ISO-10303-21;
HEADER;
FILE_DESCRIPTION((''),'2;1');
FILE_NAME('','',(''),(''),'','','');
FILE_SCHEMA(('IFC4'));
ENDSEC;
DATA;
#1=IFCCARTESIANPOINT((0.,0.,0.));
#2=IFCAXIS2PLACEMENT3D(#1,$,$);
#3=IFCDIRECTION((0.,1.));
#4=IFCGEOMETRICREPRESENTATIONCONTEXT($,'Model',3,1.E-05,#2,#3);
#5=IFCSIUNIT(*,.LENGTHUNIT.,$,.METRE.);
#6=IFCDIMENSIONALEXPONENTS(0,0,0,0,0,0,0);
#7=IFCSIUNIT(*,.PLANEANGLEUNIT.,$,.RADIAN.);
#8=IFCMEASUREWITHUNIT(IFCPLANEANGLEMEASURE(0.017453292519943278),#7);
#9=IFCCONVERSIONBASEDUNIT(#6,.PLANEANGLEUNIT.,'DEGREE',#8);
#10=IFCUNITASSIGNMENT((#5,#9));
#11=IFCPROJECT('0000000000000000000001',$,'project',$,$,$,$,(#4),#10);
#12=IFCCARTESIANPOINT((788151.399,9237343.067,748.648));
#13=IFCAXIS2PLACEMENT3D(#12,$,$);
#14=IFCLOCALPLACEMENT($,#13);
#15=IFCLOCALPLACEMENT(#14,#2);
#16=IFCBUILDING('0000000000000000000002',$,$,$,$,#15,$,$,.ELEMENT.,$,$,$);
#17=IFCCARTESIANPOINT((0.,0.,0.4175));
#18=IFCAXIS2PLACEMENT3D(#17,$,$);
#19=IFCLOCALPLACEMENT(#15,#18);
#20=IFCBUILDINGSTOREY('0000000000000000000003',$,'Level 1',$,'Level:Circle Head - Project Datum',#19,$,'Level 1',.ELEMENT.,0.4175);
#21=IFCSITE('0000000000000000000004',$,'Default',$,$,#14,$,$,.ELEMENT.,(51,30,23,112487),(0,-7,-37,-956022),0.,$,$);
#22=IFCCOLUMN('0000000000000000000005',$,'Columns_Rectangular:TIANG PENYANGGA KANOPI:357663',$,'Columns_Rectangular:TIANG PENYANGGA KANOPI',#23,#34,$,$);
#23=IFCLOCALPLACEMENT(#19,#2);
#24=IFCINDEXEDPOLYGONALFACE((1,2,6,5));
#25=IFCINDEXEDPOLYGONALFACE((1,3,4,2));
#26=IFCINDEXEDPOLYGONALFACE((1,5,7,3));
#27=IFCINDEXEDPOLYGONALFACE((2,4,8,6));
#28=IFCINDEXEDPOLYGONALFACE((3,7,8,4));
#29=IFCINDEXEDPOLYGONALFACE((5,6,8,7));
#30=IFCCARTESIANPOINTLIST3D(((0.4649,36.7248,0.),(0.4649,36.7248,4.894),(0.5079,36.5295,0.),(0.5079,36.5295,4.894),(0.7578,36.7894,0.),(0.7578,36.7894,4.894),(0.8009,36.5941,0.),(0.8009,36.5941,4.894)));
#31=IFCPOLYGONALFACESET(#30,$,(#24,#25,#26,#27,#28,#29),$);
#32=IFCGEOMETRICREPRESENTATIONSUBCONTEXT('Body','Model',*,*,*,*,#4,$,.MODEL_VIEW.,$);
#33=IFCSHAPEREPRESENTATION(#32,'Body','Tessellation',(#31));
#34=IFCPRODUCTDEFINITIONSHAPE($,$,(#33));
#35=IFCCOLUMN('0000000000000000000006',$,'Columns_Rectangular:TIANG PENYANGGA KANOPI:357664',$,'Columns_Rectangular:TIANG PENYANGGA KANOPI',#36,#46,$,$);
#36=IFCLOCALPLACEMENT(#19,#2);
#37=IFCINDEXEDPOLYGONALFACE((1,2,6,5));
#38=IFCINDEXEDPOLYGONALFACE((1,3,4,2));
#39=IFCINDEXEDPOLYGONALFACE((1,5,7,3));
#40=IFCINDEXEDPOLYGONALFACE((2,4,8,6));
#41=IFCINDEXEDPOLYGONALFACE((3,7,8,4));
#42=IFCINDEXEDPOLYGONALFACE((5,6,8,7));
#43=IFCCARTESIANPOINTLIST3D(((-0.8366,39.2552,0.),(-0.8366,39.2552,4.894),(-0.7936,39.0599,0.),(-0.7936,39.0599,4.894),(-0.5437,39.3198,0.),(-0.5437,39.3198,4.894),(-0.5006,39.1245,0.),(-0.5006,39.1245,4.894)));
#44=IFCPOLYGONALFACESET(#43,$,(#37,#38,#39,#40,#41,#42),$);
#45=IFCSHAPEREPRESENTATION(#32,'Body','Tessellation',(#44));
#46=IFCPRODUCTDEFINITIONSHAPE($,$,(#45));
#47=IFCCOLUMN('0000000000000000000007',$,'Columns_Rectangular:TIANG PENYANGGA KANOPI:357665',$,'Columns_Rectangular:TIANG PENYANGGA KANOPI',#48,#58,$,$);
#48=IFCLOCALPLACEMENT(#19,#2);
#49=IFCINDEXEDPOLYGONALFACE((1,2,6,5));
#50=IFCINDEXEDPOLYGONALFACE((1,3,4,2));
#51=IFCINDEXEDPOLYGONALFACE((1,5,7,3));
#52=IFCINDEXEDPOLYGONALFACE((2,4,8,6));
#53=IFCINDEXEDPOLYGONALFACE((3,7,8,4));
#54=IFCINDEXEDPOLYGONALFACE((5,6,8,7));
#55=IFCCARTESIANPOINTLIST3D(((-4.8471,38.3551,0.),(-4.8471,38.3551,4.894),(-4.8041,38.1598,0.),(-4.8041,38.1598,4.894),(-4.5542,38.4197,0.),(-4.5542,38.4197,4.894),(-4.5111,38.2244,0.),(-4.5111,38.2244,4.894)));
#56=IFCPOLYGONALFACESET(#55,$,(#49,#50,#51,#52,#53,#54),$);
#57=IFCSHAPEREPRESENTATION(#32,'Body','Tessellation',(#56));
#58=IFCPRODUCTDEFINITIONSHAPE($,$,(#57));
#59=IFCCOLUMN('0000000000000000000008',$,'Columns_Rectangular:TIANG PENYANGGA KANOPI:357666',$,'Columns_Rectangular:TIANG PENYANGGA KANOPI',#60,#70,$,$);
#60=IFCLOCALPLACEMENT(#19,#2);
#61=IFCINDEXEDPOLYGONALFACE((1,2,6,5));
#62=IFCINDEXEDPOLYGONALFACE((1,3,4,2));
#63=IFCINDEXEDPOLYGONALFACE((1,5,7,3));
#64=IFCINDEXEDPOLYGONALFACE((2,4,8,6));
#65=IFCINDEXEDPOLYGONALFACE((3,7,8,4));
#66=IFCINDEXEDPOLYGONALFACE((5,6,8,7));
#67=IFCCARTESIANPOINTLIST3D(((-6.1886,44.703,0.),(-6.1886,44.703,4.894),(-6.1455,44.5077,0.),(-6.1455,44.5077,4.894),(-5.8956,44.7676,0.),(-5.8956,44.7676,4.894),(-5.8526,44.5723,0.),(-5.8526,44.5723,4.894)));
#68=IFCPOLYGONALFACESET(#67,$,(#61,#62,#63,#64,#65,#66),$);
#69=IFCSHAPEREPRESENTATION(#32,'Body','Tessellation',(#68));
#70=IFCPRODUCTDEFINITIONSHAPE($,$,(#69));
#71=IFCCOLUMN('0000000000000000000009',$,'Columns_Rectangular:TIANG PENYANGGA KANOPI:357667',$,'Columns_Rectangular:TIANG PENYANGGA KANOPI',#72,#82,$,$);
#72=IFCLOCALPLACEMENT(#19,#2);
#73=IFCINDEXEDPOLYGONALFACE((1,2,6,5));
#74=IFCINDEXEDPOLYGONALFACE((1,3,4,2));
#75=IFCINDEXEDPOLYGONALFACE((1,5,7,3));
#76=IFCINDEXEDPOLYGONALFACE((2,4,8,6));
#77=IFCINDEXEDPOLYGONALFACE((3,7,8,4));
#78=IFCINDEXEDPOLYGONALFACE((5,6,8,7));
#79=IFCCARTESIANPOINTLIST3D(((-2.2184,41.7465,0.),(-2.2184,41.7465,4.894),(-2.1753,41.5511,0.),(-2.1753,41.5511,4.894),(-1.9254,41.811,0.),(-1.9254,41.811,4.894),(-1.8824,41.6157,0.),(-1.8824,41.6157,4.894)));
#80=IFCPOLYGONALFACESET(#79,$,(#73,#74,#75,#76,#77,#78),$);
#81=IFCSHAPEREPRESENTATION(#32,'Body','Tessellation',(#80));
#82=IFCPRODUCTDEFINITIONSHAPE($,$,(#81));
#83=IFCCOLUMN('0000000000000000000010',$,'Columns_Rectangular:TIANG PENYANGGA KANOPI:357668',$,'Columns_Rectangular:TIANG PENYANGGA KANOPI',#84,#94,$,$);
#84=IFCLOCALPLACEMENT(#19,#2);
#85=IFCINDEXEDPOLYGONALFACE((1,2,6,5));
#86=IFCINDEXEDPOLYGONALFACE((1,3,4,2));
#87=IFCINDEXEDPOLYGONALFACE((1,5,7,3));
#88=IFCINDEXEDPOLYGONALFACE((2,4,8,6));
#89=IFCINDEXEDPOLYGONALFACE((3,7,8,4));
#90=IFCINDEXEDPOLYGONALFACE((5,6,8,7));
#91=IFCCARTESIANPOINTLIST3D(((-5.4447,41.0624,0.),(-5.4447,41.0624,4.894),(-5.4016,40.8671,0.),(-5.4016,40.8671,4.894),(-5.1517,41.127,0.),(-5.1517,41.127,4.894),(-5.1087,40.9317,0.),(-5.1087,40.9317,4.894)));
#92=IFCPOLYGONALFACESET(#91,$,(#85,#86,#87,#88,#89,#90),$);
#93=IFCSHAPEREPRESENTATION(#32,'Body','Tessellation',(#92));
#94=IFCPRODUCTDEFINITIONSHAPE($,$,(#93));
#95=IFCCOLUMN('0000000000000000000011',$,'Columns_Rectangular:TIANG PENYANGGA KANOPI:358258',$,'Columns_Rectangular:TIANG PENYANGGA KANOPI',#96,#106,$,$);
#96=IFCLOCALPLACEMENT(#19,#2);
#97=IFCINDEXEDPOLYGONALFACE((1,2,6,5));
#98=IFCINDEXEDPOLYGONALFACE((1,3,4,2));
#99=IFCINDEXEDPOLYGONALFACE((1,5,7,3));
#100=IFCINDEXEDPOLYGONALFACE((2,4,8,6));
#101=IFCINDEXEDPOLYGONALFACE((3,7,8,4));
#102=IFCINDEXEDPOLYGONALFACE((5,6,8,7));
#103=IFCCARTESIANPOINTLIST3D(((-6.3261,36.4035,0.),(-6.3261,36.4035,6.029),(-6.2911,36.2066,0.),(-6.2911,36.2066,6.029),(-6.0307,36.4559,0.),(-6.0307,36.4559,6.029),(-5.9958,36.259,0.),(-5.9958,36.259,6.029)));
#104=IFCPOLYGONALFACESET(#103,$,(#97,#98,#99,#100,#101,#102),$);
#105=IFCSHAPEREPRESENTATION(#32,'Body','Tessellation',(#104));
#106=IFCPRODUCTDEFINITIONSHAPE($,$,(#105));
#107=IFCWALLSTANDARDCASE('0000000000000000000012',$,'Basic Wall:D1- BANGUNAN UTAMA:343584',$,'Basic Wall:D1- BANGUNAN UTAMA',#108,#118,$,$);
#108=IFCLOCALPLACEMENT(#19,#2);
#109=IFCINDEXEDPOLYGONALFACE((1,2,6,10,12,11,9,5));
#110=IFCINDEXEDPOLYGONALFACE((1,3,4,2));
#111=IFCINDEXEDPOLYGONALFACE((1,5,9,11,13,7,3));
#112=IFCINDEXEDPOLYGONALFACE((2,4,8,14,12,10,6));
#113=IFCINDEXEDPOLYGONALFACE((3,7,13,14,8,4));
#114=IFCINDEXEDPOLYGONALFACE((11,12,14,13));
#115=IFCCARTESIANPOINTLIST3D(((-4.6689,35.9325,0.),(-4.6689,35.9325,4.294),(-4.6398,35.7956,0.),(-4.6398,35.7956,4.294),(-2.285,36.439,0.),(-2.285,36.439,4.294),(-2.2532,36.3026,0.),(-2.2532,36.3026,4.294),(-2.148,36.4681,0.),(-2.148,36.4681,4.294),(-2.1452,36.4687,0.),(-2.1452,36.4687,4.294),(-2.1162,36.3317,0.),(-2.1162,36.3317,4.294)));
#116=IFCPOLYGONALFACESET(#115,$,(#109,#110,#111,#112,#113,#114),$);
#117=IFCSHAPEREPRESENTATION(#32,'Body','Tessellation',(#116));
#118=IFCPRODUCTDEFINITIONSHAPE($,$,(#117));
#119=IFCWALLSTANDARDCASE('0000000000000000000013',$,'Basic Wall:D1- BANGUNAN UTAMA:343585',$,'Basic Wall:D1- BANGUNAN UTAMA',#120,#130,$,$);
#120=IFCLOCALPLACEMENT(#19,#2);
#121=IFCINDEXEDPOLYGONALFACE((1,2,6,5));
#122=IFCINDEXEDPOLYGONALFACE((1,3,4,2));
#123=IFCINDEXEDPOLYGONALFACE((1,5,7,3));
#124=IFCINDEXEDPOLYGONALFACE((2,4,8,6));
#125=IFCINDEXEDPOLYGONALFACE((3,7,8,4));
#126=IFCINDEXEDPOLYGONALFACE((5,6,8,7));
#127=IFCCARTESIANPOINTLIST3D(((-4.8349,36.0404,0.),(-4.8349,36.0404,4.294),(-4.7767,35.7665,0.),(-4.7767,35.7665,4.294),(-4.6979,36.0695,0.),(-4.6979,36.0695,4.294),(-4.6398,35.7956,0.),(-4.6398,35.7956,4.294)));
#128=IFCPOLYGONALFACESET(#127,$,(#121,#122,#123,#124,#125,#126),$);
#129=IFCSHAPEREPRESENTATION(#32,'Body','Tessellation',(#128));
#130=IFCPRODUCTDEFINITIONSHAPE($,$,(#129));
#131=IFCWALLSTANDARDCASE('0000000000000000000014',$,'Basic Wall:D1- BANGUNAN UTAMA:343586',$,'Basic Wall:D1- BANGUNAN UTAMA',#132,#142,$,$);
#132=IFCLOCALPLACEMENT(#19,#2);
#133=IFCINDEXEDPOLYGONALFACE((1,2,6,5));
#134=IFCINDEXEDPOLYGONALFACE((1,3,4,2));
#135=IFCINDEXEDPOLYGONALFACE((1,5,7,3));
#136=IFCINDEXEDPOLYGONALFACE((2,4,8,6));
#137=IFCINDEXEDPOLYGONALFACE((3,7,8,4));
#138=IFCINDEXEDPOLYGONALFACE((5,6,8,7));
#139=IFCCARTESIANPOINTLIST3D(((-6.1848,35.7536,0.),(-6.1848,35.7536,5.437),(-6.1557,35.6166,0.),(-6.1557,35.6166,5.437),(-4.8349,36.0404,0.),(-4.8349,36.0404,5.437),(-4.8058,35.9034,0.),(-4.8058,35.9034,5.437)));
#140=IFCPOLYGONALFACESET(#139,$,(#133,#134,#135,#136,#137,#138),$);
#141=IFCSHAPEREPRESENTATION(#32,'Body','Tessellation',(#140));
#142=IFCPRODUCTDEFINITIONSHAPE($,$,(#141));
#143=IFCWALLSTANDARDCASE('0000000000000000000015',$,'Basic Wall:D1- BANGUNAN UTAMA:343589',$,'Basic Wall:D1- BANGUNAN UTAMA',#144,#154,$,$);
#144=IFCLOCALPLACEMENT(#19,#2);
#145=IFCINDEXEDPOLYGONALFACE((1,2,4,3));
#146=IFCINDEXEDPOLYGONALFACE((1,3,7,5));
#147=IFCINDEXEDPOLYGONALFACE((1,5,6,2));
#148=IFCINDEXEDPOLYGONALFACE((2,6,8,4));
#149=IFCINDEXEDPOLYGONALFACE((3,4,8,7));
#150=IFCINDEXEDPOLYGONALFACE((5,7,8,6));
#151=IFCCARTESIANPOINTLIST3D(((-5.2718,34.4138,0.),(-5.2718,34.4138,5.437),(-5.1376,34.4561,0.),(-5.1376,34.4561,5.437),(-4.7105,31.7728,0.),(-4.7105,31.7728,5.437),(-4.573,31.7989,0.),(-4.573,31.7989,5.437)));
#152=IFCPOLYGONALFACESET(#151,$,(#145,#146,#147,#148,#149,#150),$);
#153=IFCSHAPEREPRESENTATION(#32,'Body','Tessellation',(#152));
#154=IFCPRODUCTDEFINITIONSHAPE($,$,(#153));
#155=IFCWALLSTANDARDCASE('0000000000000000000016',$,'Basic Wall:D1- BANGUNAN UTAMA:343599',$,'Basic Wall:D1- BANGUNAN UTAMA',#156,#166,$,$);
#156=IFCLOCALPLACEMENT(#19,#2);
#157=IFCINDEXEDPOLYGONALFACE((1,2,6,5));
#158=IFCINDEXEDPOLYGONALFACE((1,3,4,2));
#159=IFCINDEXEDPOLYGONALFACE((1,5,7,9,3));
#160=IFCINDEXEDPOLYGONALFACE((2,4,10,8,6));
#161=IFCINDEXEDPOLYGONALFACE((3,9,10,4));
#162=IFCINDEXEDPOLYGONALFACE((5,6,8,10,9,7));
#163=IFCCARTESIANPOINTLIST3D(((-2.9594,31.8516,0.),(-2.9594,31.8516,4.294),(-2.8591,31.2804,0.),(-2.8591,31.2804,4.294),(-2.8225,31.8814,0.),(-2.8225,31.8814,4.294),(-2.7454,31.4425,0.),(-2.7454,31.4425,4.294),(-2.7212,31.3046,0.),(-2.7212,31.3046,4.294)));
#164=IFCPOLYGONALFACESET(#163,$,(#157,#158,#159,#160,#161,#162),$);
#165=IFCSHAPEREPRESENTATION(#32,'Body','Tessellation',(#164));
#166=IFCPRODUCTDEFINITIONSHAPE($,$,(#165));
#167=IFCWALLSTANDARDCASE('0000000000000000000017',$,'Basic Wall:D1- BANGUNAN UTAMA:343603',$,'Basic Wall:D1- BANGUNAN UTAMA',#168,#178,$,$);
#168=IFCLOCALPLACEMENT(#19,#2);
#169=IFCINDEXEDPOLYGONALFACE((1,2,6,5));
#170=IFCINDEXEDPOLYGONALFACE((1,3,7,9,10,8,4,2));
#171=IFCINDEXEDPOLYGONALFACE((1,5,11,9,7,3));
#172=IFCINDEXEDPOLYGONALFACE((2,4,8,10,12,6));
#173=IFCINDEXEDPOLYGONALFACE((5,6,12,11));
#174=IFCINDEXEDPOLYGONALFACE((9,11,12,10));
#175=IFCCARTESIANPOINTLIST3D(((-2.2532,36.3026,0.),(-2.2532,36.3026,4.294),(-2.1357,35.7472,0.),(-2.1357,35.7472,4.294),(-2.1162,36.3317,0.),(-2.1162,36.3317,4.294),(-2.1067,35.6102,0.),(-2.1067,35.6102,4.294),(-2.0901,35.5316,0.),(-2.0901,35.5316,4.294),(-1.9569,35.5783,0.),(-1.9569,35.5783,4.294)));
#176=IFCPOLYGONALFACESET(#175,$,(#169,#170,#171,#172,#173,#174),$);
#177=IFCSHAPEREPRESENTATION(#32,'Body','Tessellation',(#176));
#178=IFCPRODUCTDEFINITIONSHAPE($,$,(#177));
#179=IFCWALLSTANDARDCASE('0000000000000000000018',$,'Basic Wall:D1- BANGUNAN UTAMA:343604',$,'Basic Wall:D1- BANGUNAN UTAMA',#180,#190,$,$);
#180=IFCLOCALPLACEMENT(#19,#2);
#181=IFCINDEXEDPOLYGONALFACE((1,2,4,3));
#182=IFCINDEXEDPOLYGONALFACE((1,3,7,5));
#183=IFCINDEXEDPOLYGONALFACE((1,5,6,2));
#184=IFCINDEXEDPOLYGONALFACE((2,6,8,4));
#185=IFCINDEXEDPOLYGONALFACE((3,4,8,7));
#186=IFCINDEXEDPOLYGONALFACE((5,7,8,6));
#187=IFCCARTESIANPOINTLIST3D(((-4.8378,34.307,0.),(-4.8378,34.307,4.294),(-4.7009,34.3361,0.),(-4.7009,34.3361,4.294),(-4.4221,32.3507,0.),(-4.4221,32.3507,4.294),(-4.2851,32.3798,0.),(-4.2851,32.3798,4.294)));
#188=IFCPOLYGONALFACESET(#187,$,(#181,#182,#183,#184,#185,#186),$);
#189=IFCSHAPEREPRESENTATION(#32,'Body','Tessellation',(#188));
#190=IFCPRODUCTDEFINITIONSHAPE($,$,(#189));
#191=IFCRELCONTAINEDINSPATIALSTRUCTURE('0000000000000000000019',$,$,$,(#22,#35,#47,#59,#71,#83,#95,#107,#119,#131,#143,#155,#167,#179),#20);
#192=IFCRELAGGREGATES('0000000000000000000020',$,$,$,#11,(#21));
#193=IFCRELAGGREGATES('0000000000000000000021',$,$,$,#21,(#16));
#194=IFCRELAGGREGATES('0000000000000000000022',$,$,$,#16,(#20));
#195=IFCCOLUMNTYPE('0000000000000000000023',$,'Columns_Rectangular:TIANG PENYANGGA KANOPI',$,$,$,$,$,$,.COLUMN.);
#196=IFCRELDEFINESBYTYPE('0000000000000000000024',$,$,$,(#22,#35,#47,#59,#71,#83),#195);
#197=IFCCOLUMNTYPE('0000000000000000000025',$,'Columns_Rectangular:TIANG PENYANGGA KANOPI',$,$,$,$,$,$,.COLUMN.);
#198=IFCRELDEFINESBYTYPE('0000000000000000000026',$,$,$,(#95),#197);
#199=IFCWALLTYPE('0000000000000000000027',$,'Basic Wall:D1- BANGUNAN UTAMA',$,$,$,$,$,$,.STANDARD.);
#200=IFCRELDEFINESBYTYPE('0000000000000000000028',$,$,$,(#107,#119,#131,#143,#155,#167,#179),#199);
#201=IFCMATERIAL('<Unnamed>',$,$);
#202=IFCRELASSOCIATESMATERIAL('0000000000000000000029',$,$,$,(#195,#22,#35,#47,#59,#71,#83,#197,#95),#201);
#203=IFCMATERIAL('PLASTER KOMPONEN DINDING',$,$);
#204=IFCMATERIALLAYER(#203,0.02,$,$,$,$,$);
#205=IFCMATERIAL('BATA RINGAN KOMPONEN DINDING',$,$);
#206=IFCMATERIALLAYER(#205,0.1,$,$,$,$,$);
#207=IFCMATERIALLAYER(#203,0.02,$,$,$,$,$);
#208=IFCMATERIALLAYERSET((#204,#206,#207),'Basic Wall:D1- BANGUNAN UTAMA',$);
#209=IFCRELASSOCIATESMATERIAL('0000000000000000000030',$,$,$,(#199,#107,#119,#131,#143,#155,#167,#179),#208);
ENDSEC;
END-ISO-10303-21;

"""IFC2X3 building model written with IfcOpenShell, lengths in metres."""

from ifc_helpers import new_model, entity, si_unit, converted_unit, direction, frame, frame_2d, origin, origin_2d_with_axis, place, context, subcontext, project, spatial, polyline, rectangle, outline, extrude, source, transform, mapped, material, layer, layer_set, layer_usage, type_object, type_shapes, element, save


model = new_model("IFC2X3")

# Units and contexts
model_context = context("Model", 3, precision=1e-05, world=origin(), true_north=direction((0.0, 1.0)))
body_context = subcontext(model_context, "Body", "Model", "MODEL_VIEW")
ifc_project = project(units=[si_unit("LENGTHUNIT", "METRE"), converted_unit("PLANEANGLEUNIT", "DEGREE", entity("IfcPlaneAngleMeasure", 0.017453292519943278), si_unit("PLANEANGLEUNIT", "RADIAN"), dimensions=[0, 0, 0, 0, 0, 0, 0])], contexts=[model_context])

# Site, building, storey
site_placement = place(None, frame((788151.399, 9237343.067, 748.648)))
site = spatial("IfcSite", under=ifc_project, at=site_placement, Name="Default", CompositionType="ELEMENT", RefLatitude=(51, 30, 23, 112487), RefLongitude=(0, -7, -37, -956022), RefElevation=0.0)
building_placement = place(site_placement, origin())
building = spatial("IfcBuilding", under=site, at=building_placement, CompositionType="ELEMENT")
storey_placement = place(building_placement, frame((0.0, 0.0, 0.4175)))
storey = spatial("IfcBuildingStorey", under=building, at=storey_placement, Name="Level 1", ObjectType="Level:Circle Head - Project Datum", LongName="Level 1", CompositionType="ELEMENT", Elevation=0.4175)

# Columns
ifc_material_1 = material(Name="<Unnamed>")
column_type_1 = type_object("IfcColumnType", Name="Columns_Rectangular:TIANG PENYANGGA KANOPI", PredefinedType="COLUMN", material=ifc_material_1)
shared_shape_1 = source(origin(), body_context, "Body", "SweptSolid", [
    extrude(rectangle(XDim=0.2, YDim=0.3, at=origin_2d_with_axis()), frame((0.0, 0.0, 0.4175), z_axis=(0.0, 0.0, 1.0), x_axis=(0.0, 1.0, 0.0)), (0.0, 0.0, 1.0), 4.894),
])
type_shapes(column_type_1, [shared_shape_1])
for number, where, z_axis, x_axis, name in (
    (1, (0.6329, 36.6594, -0.4175), (0.0, 0.0, 1.0), (-0.976544, -0.215317, 0.0), "Columns_Rectangular:TIANG PENYANGGA KANOPI:357663"),
    (2, (-0.6686, 39.1898, -0.4175), (0.0, 0.0, 1.0), (-0.976544, -0.215317, 0.0), "Columns_Rectangular:TIANG PENYANGGA KANOPI:357664"),
    (3, (-4.6791, 38.2897, -0.4175), (0.0, 0.0, 1.0), (-0.976544, -0.215317, 0.0), "Columns_Rectangular:TIANG PENYANGGA KANOPI:357665"),
    (4, (-6.0206, 44.6377, -0.4175), (0.0, 0.0, 1.0), (-0.976544, -0.215317, 0.0), "Columns_Rectangular:TIANG PENYANGGA KANOPI:357666"),
    (5, (-2.0504, 41.6811, -0.4175), (0.0, 0.0, 1.0), (-0.976544, -0.215317, 0.0), "Columns_Rectangular:TIANG PENYANGGA KANOPI:357667"),
    (6, (-5.2767, 40.997, -0.4175), (0.0, 0.0, 1.0), (-0.976544, -0.215317, 0.0), "Columns_Rectangular:TIANG PENYANGGA KANOPI:357668"),
):
    element("IfcColumn", number, at=place(storey_placement, frame(where, z_axis=z_axis, x_axis=x_axis)), inside=storey, type_object=column_type_1, material=ifc_material_1, Name=name, ObjectType="Columns_Rectangular:TIANG PENYANGGA KANOPI", context=body_context, shape_type="MappedRepresentation", body=[
        mapped(shared_shape_1, transform((0.0, 0.0, 0.0), scale=1.0)),
    ])
column_type_2 = type_object("IfcColumnType", Name="Columns_Rectangular:TIANG PENYANGGA KANOPI", PredefinedType="COLUMN", material=ifc_material_1)
shared_shape_2 = source(origin(), body_context, "Body", "SweptSolid", [
    extrude(rectangle(XDim=0.2, YDim=0.3, at=origin_2d_with_axis()), frame((0.0, 0.0, 0.4175), z_axis=(0.0, 0.0, 1.0), x_axis=(0.0, 1.0, 0.0)), (0.0, 0.0, 1.0), 6.029),
])
type_shapes(column_type_2, [shared_shape_2])
column_placement = place(storey_placement, frame((-6.1609, 36.3312, -0.4175), z_axis=(0.0, 0.0, 1.0), x_axis=(-0.984615, -0.174737, 0.0)))
element("IfcColumn", 7, at=column_placement, inside=storey, type_object=column_type_2, material=ifc_material_1, Name="Columns_Rectangular:TIANG PENYANGGA KANOPI:358258", ObjectType="Columns_Rectangular:TIANG PENYANGGA KANOPI", context=body_context, shape_type="MappedRepresentation", body=[
    mapped(shared_shape_2, transform((0.0, 0.0, 0.0), scale=1.0)),
])

# Walls
ifc_material_2 = material(Name="PLASTER KOMPONEN DINDING")
ifc_layer_1 = layer(ifc_material_2, 0.02)
ifc_material_3 = material(Name="BATA RINGAN KOMPONEN DINDING")
ifc_layer_2 = layer(ifc_material_3, 0.1)
ifc_layer_3 = layer(ifc_material_2, 0.02)
ifc_layer_set = layer_set([ifc_layer_1, ifc_layer_2, ifc_layer_3], Name="Basic Wall:D1- BANGUNAN UTAMA")
ifc_layer_usage_1 = layer_usage(ifc_layer_set, "AXIS2", "POSITIVE", -0.07)
wall_type = type_object("IfcWallType", Name="Basic Wall:D1- BANGUNAN UTAMA", PredefinedType="STANDARD", material=ifc_layer_set)
wall_1_placement = place(storey_placement, frame((-2.1306, 36.4002, 0.0), z_axis=(0.0, 0.0, 1.0), x_axis=(-0.978168, -0.207813, 0.0)))
element("IfcWallStandardCase", 8, at=wall_1_placement, inside=storey, type_object=wall_type, material=ifc_layer_usage_1, Name="Basic Wall:D1- BANGUNAN UTAMA:343584", ObjectType="Basic Wall:D1- BANGUNAN UTAMA", context=body_context, shape_type="SweptSolid", body=[
    extrude(outline(polyline([(2.58, -0.07), (2.58, 0.07), (0.1401, 0.07), (0.0001, 0.07), (0.0, -0.07), (0.0029, -0.07), (0.1429, -0.07), (2.58, -0.07)])), origin(), (0.0, 0.0, 1.0), 4.294),
])
ifc_layer_usage_2 = layer_usage(ifc_layer_set, "AXIS2", "POSITIVE", -0.07)
wall_2_placement = place(storey_placement, frame((-4.7082, 35.781, 0.0), z_axis=(0.0, 0.0, 1.0), x_axis=(-0.207813, 0.978168, 0.0)))
element("IfcWallStandardCase", 9, at=wall_2_placement, inside=storey, type_object=wall_type, material=ifc_layer_usage_2, Name="Basic Wall:D1- BANGUNAN UTAMA:343585", ObjectType="Basic Wall:D1- BANGUNAN UTAMA", context=body_context, shape_type="SweptSolid", body=[
    extrude(rectangle(XDim=0.28, YDim=0.14, at=frame_2d((0.14, 0.0), x_axis=(-1.0, 0.0))), origin(), (0.0, 0.0, 1.0), 4.294),
])
ifc_layer_usage_3 = layer_usage(ifc_layer_set, "AXIS2", "POSITIVE", -0.07)
wall_3_placement = place(storey_placement, frame((-4.8203, 35.9719, 0.0), z_axis=(0.0, 0.0, 1.0), x_axis=(-0.978168, -0.207813, 0.0)))
element("IfcWallStandardCase", 10, at=wall_3_placement, inside=storey, type_object=wall_type, material=ifc_layer_usage_3, Name="Basic Wall:D1- BANGUNAN UTAMA:343586", ObjectType="Basic Wall:D1- BANGUNAN UTAMA", context=body_context, shape_type="SweptSolid", body=[
    extrude(rectangle(XDim=1.38, YDim=0.14, at=frame_2d((0.69, 0.0), x_axis=(-1.0, 0.0))), origin(), (0.0, 0.0, 1.0), 5.437),
])
ifc_layer_usage_4 = layer_usage(ifc_layer_set, "AXIS2", "POSITIVE", -0.07)
wall_4_placement = place(storey_placement, frame((-5.2061, 34.4416, 0.0), z_axis=(0.0, 0.0, 1.0), x_axis=(0.207863, -0.978158, 0.0)))
element("IfcWallStandardCase", 11, at=wall_4_placement, inside=storey, type_object=wall_type, material=ifc_layer_usage_4, Name="Basic Wall:D1- BANGUNAN UTAMA:343589", ObjectType="Basic Wall:D1- BANGUNAN UTAMA", context=body_context, shape_type="SweptSolid", body=[
    extrude(outline(polyline([(2.7135, -0.07), (2.7165, 0.07), (0.0, 0.07), (0.0135, -0.07), (2.7135, -0.07)])), origin(), (0.0, 0.0, 1.0), 5.437),
])
ifc_layer_usage_5 = layer_usage(ifc_layer_set, "AXIS2", "POSITIVE", -0.07)
wall_5_placement = place(storey_placement, frame((-2.8914, 31.8693, 0.0), z_axis=(0.0, 0.0, 1.0), x_axis=(0.172867, -0.984945, 0.0)))
element("IfcWallStandardCase", 12, at=wall_5_placement, inside=storey, type_object=wall_type, material=ifc_layer_usage_5, Name="Basic Wall:D1- BANGUNAN UTAMA:343599", ObjectType="Basic Wall:D1- BANGUNAN UTAMA", context=body_context, shape_type="SweptSolid", body=[
    extrude(outline(polyline([(0.5856, -0.07), (0.5856, 0.07), (0.4456, 0.07), (0.0, 0.07), (0.0056, -0.07), (0.5856, -0.07)])), origin(), (0.0, 0.0, 1.0), 4.294),
])
ifc_layer_usage_6 = layer_usage(ifc_layer_set, "AXIS2", "POSITIVE", -0.07)
wall_6_placement = place(storey_placement, frame((-2.0216, 35.5461, 0.0), z_axis=(0.0, 0.0, 1.0), x_axis=(-0.206896, 0.978363, 0.0)))
element("IfcWallStandardCase", 13, at=wall_6_placement, inside=storey, type_object=wall_type, material=ifc_layer_usage_6, Name="Basic Wall:D1- BANGUNAN UTAMA:343603", ObjectType="Basic Wall:D1- BANGUNAN UTAMA", context=body_context, shape_type="SweptSolid", body=[
    extrude(outline(polyline([(0.7882, -0.07), (0.7881, 0.07), (0.2204, 0.07), (0.0804, 0.07), (0.0, 0.07), (0.0182, -0.07), (0.7882, -0.07)])), origin(), (0.0, 0.0, 1.0), 4.294),
])
ifc_layer_usage_7 = layer_usage(ifc_layer_set, "AXIS2", "POSITIVE", -0.07)
wall_7_placement = place(storey_placement, frame((-4.7693, 34.3216, 0.0), z_axis=(0.0, 0.0, 1.0), x_axis=(0.207863, -0.978158, 0.0)))
element("IfcWallStandardCase", 14, at=wall_7_placement, inside=storey, type_object=wall_type, material=ifc_layer_usage_7, Name="Basic Wall:D1- BANGUNAN UTAMA:343604", ObjectType="Basic Wall:D1- BANGUNAN UTAMA", context=body_context, shape_type="SweptSolid", body=[
    extrude(rectangle(XDim=2.0, YDim=0.14, at=frame_2d((1.0, 0.0), x_axis=(-1.0, 0.0))), origin(), (0.0, 0.0, 1.0), 4.294),
])

save(model, "model.ifc")
